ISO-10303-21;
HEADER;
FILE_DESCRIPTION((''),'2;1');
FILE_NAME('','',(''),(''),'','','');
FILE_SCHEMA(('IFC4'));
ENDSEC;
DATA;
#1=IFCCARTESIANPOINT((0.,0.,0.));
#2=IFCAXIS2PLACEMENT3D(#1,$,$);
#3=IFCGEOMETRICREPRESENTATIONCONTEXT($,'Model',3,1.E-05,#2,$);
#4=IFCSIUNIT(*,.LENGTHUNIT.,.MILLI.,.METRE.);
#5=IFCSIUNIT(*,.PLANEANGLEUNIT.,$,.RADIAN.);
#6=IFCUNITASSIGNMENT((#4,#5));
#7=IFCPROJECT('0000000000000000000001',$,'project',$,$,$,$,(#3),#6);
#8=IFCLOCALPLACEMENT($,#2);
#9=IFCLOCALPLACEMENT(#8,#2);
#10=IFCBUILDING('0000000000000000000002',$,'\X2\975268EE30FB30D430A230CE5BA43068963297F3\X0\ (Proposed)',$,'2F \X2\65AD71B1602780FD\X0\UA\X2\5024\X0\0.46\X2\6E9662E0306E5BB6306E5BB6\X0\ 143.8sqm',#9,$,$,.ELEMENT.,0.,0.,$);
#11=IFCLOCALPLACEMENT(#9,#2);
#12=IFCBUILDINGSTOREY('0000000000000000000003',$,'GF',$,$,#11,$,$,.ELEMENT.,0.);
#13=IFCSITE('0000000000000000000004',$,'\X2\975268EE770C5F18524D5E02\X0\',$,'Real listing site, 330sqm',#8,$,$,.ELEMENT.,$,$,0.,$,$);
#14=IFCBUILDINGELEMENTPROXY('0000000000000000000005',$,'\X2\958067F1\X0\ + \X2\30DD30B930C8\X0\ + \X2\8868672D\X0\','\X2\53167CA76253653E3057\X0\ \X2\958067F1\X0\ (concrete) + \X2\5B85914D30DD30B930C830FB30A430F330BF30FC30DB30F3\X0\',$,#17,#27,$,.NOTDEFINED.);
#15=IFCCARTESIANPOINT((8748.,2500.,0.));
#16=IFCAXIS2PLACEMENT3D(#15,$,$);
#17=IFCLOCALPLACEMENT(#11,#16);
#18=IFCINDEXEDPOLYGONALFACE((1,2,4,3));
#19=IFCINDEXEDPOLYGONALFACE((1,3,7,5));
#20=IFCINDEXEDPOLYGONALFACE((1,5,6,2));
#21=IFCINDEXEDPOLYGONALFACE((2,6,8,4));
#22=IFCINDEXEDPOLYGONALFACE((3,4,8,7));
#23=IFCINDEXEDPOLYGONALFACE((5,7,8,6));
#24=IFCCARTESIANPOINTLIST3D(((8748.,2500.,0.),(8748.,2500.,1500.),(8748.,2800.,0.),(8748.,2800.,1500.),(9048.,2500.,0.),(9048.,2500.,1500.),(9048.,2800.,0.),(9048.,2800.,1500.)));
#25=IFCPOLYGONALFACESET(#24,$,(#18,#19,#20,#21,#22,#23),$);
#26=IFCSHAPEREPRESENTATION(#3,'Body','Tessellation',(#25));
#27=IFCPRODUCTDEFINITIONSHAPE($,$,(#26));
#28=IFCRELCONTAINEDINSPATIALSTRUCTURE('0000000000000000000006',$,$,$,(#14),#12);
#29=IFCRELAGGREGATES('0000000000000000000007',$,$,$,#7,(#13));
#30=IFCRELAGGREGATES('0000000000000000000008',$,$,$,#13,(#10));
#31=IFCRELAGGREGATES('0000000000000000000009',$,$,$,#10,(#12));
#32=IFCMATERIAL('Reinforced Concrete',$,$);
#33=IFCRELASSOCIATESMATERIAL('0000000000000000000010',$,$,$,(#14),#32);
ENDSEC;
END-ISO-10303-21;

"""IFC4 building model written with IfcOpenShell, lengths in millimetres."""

from ifc_helpers import new_model, si_unit, frame, frame_2d, origin, place, context, project, spatial, rectangle, extrude, material, element, save


model = new_model("IFC4")

# Units and contexts
model_context = context("Model", 3, precision=1e-05, world=origin())
ifc_project = project(units=[si_unit("LENGTHUNIT", "METRE", prefix="MILLI"), si_unit("PLANEANGLEUNIT", "RADIAN")], contexts=[model_context])

# Site, building, storey
site_placement = place(None, origin())
site = spatial("IfcSite", under=ifc_project, at=site_placement, Name="青森県弘前市", ObjectType="Real listing site, 330sqm", CompositionType="ELEMENT", RefElevation=0.0)
building_placement = place(site_placement, origin())
building = spatial("IfcBuilding", under=site, at=building_placement, Name="青森・ピアノ室と防音 (Proposed)", ObjectType="2F 断熱性能UA値0.46準拠の家の家 143.8sqm", CompositionType="ELEMENT", ElevationOfRefHeight=0.0, ElevationOfTerrain=0.0)
storey_placement = place(building_placement, origin())
storey = spatial("IfcBuildingStorey", under=building, at=storey_placement, Name="GF", CompositionType="ELEMENT", Elevation=0.0)

# Shared definitions
ifc_material_1 = material(Name="Reinforced Concrete")

# Building element proxy
proxy_placement = place(storey_placement, frame((8748.0, 2500.0, 0.0)))
element("IfcBuildingElementProxy", 1, at=proxy_placement, inside=storey, material=ifc_material_1, Name="門柱 + ポスト + 表札", Description="化粧打放し 門柱 (concrete) + 宅配ポスト・インターホン", PredefinedType="NOTDEFINED", context=model_context, shape_type="SweptSolid", body=[
    extrude(rectangle(XDim=300.0, YDim=300.0, at=frame_2d((150.0, 150.0))), frame((8748.0, 2500.0, 0.0)), (0.0, 0.0, 1.0), 1500.0),
])

save(model, "model.ifc")
